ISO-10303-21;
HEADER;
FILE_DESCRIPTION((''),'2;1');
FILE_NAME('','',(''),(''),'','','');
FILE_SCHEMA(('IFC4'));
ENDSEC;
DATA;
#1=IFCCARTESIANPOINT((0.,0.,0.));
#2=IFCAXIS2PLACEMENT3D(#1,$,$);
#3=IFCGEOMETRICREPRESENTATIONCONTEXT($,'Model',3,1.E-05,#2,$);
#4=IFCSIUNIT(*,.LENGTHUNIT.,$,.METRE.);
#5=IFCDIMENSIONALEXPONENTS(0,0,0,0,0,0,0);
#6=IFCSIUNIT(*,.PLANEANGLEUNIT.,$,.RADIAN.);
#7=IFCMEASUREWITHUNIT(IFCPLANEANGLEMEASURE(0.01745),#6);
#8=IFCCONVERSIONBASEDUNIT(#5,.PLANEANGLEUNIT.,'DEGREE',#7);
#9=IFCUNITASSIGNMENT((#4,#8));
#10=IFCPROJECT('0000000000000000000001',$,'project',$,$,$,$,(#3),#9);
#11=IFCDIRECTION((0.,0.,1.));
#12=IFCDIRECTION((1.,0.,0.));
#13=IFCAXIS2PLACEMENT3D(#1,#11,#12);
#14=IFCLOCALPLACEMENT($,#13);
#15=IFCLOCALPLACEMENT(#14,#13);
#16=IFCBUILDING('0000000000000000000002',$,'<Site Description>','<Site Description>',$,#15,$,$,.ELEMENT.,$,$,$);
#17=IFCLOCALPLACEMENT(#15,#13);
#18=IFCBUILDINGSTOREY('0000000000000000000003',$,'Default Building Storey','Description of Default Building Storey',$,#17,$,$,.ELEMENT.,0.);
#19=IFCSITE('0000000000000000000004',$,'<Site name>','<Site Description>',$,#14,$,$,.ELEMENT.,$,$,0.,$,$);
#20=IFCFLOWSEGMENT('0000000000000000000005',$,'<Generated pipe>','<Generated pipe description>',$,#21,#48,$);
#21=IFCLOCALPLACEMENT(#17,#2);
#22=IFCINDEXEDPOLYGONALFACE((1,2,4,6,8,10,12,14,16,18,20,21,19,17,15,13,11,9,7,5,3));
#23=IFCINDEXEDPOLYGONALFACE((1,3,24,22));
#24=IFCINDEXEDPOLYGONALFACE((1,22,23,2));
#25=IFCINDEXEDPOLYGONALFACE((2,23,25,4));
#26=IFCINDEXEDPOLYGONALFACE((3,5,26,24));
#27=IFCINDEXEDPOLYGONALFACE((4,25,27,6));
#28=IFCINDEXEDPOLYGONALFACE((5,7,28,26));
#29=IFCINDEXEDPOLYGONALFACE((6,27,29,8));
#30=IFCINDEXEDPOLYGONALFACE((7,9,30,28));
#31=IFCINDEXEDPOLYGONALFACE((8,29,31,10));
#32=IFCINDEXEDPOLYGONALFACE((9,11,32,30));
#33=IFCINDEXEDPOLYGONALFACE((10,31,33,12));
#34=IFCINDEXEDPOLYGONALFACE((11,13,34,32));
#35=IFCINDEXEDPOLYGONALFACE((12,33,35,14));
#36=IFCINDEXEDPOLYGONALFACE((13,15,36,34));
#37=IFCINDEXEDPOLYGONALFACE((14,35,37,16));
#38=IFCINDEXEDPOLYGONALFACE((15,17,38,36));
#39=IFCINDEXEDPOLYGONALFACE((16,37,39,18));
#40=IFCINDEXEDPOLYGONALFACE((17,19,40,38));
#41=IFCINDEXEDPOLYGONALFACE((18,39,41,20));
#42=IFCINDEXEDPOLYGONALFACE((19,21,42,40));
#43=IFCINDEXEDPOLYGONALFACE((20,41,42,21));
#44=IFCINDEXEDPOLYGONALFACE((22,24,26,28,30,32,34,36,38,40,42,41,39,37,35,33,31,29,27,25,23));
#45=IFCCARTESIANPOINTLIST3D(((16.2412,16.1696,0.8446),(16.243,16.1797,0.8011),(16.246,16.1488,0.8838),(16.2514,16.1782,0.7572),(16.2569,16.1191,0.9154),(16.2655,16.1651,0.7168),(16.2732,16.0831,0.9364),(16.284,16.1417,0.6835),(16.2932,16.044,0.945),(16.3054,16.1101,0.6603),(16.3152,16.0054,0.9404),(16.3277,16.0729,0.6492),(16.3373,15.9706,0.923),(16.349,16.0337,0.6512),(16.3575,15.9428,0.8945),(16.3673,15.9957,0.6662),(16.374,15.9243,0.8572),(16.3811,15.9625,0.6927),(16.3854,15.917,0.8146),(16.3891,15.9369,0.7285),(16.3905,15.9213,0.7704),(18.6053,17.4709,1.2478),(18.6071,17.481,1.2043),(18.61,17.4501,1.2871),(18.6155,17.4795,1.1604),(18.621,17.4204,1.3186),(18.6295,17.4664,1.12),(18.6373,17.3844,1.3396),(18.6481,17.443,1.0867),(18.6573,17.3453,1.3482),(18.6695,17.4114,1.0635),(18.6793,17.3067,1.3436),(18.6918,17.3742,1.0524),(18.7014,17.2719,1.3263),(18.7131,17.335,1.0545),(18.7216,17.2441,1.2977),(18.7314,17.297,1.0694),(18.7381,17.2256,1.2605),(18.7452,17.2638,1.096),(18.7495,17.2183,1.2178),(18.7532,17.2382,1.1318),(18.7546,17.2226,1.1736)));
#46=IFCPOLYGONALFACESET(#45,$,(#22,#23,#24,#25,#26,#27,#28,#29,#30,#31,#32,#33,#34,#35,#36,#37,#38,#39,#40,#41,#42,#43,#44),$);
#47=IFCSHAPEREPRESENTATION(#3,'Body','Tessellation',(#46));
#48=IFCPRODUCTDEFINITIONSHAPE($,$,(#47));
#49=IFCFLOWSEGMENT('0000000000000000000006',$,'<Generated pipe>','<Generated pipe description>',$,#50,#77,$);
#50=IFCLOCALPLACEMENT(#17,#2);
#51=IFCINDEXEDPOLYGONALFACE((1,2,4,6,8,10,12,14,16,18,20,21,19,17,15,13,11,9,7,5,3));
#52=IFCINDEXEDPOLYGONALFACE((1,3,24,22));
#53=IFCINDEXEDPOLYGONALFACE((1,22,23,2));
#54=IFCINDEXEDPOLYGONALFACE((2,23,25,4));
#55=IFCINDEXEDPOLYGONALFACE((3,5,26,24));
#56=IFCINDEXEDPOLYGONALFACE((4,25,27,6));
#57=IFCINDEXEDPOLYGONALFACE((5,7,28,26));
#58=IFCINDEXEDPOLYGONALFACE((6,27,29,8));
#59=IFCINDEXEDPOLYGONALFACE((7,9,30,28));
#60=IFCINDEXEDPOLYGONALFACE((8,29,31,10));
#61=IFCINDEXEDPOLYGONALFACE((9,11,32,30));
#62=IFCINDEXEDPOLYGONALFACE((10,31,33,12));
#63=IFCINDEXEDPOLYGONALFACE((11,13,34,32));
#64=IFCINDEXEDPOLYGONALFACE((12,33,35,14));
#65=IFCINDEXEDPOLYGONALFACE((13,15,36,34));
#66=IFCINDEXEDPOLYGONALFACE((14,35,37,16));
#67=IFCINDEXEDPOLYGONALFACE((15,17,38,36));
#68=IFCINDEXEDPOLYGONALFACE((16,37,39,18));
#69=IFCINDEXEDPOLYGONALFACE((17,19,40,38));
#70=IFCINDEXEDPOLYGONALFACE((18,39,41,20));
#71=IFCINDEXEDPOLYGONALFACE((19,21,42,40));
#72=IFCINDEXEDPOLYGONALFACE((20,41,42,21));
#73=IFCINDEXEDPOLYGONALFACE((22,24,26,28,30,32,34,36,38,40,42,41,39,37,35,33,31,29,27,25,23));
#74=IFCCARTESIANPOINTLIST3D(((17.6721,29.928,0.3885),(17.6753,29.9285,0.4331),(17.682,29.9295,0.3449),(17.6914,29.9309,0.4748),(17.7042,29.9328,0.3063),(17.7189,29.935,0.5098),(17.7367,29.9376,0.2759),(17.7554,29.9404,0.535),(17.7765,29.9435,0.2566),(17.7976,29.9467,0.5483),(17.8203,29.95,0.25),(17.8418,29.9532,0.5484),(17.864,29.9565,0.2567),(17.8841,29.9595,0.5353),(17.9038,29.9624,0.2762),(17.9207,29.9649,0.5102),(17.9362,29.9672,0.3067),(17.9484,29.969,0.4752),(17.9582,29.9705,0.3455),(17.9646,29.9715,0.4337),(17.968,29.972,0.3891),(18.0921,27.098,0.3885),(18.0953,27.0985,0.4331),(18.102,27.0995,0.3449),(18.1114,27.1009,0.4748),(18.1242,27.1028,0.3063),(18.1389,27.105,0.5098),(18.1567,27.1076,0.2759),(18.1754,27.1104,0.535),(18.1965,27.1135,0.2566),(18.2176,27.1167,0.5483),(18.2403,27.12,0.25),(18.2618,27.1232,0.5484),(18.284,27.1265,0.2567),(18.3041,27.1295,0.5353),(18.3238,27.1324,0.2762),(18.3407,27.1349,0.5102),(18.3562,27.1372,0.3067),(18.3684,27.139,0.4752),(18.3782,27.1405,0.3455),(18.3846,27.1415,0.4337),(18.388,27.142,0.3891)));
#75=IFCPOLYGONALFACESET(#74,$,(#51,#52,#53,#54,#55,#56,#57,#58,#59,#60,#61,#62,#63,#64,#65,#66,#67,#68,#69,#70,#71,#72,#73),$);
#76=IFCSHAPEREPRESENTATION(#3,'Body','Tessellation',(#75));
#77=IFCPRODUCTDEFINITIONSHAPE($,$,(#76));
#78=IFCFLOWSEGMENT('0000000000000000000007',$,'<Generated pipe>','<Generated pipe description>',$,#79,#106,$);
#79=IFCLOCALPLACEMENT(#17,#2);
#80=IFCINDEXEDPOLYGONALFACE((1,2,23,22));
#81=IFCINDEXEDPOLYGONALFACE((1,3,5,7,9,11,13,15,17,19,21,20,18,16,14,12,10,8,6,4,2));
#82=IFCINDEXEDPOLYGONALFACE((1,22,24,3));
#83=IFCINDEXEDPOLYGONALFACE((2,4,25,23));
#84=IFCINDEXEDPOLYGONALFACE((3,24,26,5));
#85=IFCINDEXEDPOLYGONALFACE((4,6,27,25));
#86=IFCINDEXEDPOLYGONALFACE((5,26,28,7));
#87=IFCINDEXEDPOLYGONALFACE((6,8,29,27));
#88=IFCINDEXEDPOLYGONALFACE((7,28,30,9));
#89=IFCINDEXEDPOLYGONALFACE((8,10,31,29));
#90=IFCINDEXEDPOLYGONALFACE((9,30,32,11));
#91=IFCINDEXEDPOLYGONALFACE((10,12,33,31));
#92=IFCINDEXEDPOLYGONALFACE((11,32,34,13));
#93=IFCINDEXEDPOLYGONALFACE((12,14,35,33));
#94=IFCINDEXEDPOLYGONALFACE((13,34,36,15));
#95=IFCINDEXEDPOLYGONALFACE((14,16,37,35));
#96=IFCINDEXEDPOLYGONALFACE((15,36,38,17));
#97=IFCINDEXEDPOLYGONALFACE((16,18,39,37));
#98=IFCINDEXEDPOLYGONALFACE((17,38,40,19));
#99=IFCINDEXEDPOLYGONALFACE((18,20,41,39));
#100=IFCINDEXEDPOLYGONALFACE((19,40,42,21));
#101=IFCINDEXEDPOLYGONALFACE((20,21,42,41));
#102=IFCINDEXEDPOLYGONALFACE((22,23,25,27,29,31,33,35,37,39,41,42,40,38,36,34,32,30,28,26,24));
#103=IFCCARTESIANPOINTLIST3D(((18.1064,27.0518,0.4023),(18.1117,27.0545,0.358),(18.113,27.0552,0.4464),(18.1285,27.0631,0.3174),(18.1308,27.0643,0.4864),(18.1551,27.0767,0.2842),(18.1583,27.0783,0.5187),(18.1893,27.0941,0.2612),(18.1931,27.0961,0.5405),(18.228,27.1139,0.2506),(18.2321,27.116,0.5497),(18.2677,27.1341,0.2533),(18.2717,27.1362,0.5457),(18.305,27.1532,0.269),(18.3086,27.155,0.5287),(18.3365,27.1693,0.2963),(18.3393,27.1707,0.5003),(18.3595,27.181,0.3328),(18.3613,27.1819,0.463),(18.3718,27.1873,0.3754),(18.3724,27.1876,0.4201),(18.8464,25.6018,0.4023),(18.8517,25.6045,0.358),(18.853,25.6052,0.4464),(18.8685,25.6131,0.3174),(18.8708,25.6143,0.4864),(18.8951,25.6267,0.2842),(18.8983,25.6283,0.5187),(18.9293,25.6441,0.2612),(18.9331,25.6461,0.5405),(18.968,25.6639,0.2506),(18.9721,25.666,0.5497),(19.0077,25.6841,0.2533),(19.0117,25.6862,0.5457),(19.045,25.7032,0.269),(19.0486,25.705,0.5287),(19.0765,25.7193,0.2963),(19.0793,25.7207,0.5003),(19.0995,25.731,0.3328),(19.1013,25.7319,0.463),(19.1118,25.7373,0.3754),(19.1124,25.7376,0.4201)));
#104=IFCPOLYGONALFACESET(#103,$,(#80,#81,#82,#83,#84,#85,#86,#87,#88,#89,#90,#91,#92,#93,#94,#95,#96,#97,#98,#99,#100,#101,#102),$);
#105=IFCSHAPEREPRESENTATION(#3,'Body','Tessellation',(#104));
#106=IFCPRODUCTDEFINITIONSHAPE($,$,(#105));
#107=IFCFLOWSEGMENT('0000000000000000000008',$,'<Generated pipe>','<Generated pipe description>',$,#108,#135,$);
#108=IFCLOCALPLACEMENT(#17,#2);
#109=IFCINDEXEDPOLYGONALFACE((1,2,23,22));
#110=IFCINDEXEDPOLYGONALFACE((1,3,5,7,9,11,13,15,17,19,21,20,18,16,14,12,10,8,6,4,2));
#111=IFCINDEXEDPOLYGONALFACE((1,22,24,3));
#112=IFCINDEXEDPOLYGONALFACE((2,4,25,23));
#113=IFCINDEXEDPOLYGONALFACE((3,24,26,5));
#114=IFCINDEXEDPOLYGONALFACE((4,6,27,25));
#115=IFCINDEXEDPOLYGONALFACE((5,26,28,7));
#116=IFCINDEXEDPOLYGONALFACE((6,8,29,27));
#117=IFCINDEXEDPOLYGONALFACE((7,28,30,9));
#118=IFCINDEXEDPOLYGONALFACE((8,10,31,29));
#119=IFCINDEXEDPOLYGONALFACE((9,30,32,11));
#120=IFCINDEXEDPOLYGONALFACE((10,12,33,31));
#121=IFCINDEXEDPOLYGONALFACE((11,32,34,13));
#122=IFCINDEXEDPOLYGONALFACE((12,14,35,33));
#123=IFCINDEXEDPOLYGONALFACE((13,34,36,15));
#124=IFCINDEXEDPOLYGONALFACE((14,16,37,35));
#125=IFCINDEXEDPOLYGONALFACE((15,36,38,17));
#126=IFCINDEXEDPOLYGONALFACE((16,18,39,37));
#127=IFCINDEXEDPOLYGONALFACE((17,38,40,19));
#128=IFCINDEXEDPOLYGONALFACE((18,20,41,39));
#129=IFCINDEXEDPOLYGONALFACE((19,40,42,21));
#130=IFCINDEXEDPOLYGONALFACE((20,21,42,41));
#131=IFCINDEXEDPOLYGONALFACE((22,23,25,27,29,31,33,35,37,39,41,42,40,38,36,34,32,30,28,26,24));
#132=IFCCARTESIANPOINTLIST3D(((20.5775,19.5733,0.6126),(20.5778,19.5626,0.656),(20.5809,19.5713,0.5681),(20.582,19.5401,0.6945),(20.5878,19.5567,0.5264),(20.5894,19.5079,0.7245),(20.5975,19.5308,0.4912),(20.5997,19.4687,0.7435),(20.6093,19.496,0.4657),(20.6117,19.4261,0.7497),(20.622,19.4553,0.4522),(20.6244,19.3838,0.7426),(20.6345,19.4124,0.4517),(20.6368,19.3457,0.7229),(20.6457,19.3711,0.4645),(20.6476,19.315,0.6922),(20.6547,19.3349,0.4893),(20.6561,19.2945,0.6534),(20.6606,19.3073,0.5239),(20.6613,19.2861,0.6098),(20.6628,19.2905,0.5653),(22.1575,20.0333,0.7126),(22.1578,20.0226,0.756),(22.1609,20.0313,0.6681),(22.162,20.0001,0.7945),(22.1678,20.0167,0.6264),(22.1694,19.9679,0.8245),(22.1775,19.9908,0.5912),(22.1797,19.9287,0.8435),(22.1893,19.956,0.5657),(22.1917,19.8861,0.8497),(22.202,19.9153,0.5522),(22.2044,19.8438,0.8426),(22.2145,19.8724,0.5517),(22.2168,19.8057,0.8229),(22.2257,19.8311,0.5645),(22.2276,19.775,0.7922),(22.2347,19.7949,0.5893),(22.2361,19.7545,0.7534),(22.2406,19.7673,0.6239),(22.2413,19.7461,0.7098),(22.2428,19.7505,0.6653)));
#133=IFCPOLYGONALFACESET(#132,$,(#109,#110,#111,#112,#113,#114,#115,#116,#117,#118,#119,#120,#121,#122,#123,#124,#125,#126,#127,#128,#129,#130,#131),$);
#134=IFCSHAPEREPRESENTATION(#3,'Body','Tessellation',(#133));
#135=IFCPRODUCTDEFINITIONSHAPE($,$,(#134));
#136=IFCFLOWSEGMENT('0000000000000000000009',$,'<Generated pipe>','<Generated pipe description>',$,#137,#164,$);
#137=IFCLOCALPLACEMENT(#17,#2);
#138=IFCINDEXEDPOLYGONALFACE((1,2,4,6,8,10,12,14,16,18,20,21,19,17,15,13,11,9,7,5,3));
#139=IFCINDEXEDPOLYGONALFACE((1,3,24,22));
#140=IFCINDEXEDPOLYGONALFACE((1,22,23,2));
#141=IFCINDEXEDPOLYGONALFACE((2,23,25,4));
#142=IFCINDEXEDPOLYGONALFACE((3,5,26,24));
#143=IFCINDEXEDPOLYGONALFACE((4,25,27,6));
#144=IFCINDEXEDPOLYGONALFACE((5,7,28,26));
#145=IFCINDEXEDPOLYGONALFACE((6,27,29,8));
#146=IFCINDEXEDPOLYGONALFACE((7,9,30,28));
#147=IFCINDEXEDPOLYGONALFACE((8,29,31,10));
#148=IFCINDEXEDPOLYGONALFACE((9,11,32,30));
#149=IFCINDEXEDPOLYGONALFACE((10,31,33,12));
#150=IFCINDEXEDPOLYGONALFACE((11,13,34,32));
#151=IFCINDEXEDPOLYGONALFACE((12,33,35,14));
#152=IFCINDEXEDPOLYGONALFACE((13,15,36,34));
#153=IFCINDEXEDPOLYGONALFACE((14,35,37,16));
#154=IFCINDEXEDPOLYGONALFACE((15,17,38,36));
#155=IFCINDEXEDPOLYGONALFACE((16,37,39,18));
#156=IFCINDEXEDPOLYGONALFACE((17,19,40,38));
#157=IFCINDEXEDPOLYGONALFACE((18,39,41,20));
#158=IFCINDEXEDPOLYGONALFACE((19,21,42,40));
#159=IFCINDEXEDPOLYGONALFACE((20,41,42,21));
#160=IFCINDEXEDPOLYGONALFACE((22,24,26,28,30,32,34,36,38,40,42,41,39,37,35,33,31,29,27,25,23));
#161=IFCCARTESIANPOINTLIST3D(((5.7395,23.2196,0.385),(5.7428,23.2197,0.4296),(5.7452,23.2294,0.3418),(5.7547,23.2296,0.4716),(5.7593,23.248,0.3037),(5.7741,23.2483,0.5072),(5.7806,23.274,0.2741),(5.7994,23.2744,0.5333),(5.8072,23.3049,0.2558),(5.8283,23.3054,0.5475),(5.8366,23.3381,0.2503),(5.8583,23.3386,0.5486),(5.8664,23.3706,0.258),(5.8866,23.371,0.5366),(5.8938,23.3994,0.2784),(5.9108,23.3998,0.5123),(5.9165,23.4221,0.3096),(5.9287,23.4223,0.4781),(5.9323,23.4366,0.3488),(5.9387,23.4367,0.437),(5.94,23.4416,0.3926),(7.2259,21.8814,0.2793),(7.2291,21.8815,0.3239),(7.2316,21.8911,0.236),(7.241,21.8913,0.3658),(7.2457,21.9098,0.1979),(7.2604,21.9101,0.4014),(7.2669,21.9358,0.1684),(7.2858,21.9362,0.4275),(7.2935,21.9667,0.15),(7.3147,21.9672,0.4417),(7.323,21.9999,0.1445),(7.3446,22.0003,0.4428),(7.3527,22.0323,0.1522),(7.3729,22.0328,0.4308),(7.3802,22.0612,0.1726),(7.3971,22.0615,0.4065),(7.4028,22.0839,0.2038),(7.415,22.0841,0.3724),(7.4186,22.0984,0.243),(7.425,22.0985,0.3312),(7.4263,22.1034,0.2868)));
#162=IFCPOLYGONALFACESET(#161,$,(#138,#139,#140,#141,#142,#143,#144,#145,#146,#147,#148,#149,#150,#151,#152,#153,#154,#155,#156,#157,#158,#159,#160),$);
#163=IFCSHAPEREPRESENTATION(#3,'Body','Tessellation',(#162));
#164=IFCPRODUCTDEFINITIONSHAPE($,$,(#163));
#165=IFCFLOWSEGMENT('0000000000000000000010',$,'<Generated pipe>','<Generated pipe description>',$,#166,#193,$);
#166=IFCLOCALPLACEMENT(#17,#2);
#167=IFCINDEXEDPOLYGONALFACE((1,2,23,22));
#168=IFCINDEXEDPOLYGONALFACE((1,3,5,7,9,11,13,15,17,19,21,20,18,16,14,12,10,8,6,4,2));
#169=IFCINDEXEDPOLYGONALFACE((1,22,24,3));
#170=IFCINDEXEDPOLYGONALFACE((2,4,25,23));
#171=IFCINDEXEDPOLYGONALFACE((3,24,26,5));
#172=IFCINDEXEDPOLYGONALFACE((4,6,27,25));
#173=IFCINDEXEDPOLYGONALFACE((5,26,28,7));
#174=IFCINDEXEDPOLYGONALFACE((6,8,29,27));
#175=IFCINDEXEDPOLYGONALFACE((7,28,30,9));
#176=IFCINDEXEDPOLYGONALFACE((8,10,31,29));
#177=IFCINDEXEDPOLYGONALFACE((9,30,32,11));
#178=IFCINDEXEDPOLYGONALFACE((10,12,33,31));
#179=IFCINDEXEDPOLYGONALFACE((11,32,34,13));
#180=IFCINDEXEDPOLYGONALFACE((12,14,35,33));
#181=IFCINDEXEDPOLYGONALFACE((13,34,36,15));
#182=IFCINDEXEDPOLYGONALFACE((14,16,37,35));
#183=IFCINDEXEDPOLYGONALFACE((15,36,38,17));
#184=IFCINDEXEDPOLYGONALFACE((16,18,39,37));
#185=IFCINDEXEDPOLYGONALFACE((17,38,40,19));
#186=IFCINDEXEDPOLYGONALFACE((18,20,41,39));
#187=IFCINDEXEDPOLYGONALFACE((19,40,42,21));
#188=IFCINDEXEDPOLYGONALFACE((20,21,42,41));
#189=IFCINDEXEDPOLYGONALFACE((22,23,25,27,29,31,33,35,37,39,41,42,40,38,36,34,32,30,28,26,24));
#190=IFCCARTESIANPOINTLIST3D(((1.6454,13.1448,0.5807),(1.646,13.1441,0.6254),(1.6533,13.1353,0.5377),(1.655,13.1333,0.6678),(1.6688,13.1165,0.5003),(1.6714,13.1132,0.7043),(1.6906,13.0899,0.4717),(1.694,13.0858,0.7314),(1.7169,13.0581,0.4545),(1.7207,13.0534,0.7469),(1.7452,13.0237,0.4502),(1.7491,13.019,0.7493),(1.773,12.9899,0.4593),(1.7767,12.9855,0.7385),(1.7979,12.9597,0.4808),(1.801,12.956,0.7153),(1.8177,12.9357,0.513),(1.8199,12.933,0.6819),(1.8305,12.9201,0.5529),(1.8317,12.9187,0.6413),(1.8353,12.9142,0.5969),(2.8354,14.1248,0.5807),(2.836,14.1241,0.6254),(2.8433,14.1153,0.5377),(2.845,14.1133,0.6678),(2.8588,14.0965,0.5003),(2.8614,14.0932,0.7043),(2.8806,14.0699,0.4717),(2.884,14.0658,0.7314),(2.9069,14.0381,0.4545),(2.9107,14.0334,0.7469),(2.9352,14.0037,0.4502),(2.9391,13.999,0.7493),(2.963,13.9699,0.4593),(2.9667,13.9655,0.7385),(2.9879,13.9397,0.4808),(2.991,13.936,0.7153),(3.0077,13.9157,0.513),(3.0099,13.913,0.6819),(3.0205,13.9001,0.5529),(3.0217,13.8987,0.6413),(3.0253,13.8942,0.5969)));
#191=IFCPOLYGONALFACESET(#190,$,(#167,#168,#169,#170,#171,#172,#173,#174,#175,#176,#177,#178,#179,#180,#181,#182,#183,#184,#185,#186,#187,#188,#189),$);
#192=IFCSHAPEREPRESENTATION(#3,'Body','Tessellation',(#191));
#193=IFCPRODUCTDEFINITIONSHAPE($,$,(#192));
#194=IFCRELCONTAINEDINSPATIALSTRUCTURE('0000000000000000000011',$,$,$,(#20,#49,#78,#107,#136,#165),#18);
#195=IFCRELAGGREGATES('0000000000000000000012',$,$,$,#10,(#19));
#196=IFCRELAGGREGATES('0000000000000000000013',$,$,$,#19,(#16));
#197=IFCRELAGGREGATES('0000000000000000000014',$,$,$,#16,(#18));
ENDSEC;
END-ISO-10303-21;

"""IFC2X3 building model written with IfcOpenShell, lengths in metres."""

from ifc_helpers import new_model, entity, si_unit, converted_unit, frame, origin, origin_with_axes, origin_2d_with_axis, place, context, project, spatial, circle, extrude, element, save


model = new_model("IFC2X3")

# Units and contexts
model_context = context("Model", 3, precision=1e-05, world=origin())
ifc_project = project(units=[si_unit("LENGTHUNIT", "METRE"), converted_unit("PLANEANGLEUNIT", "DEGREE", entity("IfcPlaneAngleMeasure", 0.01745), si_unit("PLANEANGLEUNIT", "RADIAN"), dimensions=[0, 0, 0, 0, 0, 0, 0])], contexts=[model_context])

# Site, building, storey
site_placement = place(None, origin_with_axes())
site = spatial("IfcSite", under=ifc_project, at=site_placement, Name="<Site name>", Description="<Site Description>", CompositionType="ELEMENT", RefElevation=0.0)
building_placement = place(site_placement, origin_with_axes())
building = spatial("IfcBuilding", under=site, at=building_placement, Name="<Site Description>", Description="<Site Description>", CompositionType="ELEMENT")
storey_placement = place(building_placement, origin_with_axes())
storey = spatial("IfcBuildingStorey", under=building, at=storey_placement, Name="Default Building Storey", Description="Description of Default Building Storey", CompositionType="ELEMENT", Elevation=0.0)

# Flow segments
flow_segment_1_placement = place(storey_placement, frame((16.3159, 16.0487, 0.7968), z_axis=(0.866431, 0.476923, 0.147786), x_axis=(-0.284922, 0.229206, 0.930744)))
element("IfcFlowSegment", 1, at=flow_segment_1_placement, inside=storey, Name="<Generated pipe>", Description="<Generated pipe description>", context=model_context, shape_type="SweptSolid", body=[
    extrude(circle(Radius=0.15, at=origin_2d_with_axis()), origin_with_axes(), (0.0, 0.0, 1.0), 2.7285),
])
flow_segment_2_placement = place(storey_placement, frame((17.82, 29.95, 0.4), z_axis=(0.146802, -0.989166, 0.0), x_axis=(0.671418, 0.099645, 0.734349)))
element("IfcFlowSegment", 2, at=flow_segment_2_placement, inside=storey, Name="<Generated pipe>", Description="<Generated pipe description>", context=model_context, shape_type="SweptSolid", body=[
    extrude(circle(Radius=0.15, at=origin_2d_with_axis()), origin_with_axes(), (0.0, 0.0, 1.0), 2.861),
])
flow_segment_3_placement = place(storey_placement, frame((18.24, 27.12, 0.4), z_axis=(0.45457, -0.890711, 0.0), x_axis=(0.457243, 0.233352, 0.858182)))
element("IfcFlowSegment", 3, at=flow_segment_3_placement, inside=storey, Name="<Generated pipe>", Description="<Generated pipe description>", context=model_context, shape_type="SweptSolid", body=[
    extrude(circle(Radius=0.15, at=origin_2d_with_axis()), origin_with_axes(), (0.0, 0.0, 1.0), 1.6279),
])
flow_segment_4_placement = place(storey_placement, frame((20.62, 19.43, 0.6), z_axis=(0.958368, 0.279019, 0.060656), x_axis=(-0.203692, 0.519199, 0.830025)))
element("IfcFlowSegment", 4, at=flow_segment_4_placement, inside=storey, Name="<Generated pipe>", Description="<Generated pipe description>", context=model_context, shape_type="SweptSolid", body=[
    extrude(circle(Radius=0.15, at=origin_2d_with_axis()), origin_with_axes(), (0.0, 0.0, 1.0), 1.6486),
])
flow_segment_5_placement = place(storey_placement, frame((5.84, 23.33, 0.4), z_axis=(0.742125, -0.668177, -0.05282), x_axis=(0.472044, 0.465083, 0.748914)))
element("IfcFlowSegment", 5, at=flow_segment_5_placement, inside=storey, Name="<Generated pipe>", Description="<Generated pipe description>", context=model_context, shape_type="SweptSolid", body=[
    extrude(circle(Radius=0.15, at=origin_2d_with_axis()), origin_with_axes(), (0.0, 0.0, 1.0), 2.0028),
])
flow_segment_6_placement = place(storey_placement, frame((1.74, 13.03, 0.6), z_axis=(0.77193, 0.635707, 0.0), x_axis=(0.060495, -0.073458, 0.995462)))
element("IfcFlowSegment", 6, at=flow_segment_6_placement, inside=storey, Name="<Generated pipe>", Description="<Generated pipe description>", context=model_context, shape_type="SweptSolid", body=[
    extrude(circle(Radius=0.15, at=origin_2d_with_axis()), origin_with_axes(), (0.0, 0.0, 1.0), 1.5416),
])

save(model, "model.ifc")
